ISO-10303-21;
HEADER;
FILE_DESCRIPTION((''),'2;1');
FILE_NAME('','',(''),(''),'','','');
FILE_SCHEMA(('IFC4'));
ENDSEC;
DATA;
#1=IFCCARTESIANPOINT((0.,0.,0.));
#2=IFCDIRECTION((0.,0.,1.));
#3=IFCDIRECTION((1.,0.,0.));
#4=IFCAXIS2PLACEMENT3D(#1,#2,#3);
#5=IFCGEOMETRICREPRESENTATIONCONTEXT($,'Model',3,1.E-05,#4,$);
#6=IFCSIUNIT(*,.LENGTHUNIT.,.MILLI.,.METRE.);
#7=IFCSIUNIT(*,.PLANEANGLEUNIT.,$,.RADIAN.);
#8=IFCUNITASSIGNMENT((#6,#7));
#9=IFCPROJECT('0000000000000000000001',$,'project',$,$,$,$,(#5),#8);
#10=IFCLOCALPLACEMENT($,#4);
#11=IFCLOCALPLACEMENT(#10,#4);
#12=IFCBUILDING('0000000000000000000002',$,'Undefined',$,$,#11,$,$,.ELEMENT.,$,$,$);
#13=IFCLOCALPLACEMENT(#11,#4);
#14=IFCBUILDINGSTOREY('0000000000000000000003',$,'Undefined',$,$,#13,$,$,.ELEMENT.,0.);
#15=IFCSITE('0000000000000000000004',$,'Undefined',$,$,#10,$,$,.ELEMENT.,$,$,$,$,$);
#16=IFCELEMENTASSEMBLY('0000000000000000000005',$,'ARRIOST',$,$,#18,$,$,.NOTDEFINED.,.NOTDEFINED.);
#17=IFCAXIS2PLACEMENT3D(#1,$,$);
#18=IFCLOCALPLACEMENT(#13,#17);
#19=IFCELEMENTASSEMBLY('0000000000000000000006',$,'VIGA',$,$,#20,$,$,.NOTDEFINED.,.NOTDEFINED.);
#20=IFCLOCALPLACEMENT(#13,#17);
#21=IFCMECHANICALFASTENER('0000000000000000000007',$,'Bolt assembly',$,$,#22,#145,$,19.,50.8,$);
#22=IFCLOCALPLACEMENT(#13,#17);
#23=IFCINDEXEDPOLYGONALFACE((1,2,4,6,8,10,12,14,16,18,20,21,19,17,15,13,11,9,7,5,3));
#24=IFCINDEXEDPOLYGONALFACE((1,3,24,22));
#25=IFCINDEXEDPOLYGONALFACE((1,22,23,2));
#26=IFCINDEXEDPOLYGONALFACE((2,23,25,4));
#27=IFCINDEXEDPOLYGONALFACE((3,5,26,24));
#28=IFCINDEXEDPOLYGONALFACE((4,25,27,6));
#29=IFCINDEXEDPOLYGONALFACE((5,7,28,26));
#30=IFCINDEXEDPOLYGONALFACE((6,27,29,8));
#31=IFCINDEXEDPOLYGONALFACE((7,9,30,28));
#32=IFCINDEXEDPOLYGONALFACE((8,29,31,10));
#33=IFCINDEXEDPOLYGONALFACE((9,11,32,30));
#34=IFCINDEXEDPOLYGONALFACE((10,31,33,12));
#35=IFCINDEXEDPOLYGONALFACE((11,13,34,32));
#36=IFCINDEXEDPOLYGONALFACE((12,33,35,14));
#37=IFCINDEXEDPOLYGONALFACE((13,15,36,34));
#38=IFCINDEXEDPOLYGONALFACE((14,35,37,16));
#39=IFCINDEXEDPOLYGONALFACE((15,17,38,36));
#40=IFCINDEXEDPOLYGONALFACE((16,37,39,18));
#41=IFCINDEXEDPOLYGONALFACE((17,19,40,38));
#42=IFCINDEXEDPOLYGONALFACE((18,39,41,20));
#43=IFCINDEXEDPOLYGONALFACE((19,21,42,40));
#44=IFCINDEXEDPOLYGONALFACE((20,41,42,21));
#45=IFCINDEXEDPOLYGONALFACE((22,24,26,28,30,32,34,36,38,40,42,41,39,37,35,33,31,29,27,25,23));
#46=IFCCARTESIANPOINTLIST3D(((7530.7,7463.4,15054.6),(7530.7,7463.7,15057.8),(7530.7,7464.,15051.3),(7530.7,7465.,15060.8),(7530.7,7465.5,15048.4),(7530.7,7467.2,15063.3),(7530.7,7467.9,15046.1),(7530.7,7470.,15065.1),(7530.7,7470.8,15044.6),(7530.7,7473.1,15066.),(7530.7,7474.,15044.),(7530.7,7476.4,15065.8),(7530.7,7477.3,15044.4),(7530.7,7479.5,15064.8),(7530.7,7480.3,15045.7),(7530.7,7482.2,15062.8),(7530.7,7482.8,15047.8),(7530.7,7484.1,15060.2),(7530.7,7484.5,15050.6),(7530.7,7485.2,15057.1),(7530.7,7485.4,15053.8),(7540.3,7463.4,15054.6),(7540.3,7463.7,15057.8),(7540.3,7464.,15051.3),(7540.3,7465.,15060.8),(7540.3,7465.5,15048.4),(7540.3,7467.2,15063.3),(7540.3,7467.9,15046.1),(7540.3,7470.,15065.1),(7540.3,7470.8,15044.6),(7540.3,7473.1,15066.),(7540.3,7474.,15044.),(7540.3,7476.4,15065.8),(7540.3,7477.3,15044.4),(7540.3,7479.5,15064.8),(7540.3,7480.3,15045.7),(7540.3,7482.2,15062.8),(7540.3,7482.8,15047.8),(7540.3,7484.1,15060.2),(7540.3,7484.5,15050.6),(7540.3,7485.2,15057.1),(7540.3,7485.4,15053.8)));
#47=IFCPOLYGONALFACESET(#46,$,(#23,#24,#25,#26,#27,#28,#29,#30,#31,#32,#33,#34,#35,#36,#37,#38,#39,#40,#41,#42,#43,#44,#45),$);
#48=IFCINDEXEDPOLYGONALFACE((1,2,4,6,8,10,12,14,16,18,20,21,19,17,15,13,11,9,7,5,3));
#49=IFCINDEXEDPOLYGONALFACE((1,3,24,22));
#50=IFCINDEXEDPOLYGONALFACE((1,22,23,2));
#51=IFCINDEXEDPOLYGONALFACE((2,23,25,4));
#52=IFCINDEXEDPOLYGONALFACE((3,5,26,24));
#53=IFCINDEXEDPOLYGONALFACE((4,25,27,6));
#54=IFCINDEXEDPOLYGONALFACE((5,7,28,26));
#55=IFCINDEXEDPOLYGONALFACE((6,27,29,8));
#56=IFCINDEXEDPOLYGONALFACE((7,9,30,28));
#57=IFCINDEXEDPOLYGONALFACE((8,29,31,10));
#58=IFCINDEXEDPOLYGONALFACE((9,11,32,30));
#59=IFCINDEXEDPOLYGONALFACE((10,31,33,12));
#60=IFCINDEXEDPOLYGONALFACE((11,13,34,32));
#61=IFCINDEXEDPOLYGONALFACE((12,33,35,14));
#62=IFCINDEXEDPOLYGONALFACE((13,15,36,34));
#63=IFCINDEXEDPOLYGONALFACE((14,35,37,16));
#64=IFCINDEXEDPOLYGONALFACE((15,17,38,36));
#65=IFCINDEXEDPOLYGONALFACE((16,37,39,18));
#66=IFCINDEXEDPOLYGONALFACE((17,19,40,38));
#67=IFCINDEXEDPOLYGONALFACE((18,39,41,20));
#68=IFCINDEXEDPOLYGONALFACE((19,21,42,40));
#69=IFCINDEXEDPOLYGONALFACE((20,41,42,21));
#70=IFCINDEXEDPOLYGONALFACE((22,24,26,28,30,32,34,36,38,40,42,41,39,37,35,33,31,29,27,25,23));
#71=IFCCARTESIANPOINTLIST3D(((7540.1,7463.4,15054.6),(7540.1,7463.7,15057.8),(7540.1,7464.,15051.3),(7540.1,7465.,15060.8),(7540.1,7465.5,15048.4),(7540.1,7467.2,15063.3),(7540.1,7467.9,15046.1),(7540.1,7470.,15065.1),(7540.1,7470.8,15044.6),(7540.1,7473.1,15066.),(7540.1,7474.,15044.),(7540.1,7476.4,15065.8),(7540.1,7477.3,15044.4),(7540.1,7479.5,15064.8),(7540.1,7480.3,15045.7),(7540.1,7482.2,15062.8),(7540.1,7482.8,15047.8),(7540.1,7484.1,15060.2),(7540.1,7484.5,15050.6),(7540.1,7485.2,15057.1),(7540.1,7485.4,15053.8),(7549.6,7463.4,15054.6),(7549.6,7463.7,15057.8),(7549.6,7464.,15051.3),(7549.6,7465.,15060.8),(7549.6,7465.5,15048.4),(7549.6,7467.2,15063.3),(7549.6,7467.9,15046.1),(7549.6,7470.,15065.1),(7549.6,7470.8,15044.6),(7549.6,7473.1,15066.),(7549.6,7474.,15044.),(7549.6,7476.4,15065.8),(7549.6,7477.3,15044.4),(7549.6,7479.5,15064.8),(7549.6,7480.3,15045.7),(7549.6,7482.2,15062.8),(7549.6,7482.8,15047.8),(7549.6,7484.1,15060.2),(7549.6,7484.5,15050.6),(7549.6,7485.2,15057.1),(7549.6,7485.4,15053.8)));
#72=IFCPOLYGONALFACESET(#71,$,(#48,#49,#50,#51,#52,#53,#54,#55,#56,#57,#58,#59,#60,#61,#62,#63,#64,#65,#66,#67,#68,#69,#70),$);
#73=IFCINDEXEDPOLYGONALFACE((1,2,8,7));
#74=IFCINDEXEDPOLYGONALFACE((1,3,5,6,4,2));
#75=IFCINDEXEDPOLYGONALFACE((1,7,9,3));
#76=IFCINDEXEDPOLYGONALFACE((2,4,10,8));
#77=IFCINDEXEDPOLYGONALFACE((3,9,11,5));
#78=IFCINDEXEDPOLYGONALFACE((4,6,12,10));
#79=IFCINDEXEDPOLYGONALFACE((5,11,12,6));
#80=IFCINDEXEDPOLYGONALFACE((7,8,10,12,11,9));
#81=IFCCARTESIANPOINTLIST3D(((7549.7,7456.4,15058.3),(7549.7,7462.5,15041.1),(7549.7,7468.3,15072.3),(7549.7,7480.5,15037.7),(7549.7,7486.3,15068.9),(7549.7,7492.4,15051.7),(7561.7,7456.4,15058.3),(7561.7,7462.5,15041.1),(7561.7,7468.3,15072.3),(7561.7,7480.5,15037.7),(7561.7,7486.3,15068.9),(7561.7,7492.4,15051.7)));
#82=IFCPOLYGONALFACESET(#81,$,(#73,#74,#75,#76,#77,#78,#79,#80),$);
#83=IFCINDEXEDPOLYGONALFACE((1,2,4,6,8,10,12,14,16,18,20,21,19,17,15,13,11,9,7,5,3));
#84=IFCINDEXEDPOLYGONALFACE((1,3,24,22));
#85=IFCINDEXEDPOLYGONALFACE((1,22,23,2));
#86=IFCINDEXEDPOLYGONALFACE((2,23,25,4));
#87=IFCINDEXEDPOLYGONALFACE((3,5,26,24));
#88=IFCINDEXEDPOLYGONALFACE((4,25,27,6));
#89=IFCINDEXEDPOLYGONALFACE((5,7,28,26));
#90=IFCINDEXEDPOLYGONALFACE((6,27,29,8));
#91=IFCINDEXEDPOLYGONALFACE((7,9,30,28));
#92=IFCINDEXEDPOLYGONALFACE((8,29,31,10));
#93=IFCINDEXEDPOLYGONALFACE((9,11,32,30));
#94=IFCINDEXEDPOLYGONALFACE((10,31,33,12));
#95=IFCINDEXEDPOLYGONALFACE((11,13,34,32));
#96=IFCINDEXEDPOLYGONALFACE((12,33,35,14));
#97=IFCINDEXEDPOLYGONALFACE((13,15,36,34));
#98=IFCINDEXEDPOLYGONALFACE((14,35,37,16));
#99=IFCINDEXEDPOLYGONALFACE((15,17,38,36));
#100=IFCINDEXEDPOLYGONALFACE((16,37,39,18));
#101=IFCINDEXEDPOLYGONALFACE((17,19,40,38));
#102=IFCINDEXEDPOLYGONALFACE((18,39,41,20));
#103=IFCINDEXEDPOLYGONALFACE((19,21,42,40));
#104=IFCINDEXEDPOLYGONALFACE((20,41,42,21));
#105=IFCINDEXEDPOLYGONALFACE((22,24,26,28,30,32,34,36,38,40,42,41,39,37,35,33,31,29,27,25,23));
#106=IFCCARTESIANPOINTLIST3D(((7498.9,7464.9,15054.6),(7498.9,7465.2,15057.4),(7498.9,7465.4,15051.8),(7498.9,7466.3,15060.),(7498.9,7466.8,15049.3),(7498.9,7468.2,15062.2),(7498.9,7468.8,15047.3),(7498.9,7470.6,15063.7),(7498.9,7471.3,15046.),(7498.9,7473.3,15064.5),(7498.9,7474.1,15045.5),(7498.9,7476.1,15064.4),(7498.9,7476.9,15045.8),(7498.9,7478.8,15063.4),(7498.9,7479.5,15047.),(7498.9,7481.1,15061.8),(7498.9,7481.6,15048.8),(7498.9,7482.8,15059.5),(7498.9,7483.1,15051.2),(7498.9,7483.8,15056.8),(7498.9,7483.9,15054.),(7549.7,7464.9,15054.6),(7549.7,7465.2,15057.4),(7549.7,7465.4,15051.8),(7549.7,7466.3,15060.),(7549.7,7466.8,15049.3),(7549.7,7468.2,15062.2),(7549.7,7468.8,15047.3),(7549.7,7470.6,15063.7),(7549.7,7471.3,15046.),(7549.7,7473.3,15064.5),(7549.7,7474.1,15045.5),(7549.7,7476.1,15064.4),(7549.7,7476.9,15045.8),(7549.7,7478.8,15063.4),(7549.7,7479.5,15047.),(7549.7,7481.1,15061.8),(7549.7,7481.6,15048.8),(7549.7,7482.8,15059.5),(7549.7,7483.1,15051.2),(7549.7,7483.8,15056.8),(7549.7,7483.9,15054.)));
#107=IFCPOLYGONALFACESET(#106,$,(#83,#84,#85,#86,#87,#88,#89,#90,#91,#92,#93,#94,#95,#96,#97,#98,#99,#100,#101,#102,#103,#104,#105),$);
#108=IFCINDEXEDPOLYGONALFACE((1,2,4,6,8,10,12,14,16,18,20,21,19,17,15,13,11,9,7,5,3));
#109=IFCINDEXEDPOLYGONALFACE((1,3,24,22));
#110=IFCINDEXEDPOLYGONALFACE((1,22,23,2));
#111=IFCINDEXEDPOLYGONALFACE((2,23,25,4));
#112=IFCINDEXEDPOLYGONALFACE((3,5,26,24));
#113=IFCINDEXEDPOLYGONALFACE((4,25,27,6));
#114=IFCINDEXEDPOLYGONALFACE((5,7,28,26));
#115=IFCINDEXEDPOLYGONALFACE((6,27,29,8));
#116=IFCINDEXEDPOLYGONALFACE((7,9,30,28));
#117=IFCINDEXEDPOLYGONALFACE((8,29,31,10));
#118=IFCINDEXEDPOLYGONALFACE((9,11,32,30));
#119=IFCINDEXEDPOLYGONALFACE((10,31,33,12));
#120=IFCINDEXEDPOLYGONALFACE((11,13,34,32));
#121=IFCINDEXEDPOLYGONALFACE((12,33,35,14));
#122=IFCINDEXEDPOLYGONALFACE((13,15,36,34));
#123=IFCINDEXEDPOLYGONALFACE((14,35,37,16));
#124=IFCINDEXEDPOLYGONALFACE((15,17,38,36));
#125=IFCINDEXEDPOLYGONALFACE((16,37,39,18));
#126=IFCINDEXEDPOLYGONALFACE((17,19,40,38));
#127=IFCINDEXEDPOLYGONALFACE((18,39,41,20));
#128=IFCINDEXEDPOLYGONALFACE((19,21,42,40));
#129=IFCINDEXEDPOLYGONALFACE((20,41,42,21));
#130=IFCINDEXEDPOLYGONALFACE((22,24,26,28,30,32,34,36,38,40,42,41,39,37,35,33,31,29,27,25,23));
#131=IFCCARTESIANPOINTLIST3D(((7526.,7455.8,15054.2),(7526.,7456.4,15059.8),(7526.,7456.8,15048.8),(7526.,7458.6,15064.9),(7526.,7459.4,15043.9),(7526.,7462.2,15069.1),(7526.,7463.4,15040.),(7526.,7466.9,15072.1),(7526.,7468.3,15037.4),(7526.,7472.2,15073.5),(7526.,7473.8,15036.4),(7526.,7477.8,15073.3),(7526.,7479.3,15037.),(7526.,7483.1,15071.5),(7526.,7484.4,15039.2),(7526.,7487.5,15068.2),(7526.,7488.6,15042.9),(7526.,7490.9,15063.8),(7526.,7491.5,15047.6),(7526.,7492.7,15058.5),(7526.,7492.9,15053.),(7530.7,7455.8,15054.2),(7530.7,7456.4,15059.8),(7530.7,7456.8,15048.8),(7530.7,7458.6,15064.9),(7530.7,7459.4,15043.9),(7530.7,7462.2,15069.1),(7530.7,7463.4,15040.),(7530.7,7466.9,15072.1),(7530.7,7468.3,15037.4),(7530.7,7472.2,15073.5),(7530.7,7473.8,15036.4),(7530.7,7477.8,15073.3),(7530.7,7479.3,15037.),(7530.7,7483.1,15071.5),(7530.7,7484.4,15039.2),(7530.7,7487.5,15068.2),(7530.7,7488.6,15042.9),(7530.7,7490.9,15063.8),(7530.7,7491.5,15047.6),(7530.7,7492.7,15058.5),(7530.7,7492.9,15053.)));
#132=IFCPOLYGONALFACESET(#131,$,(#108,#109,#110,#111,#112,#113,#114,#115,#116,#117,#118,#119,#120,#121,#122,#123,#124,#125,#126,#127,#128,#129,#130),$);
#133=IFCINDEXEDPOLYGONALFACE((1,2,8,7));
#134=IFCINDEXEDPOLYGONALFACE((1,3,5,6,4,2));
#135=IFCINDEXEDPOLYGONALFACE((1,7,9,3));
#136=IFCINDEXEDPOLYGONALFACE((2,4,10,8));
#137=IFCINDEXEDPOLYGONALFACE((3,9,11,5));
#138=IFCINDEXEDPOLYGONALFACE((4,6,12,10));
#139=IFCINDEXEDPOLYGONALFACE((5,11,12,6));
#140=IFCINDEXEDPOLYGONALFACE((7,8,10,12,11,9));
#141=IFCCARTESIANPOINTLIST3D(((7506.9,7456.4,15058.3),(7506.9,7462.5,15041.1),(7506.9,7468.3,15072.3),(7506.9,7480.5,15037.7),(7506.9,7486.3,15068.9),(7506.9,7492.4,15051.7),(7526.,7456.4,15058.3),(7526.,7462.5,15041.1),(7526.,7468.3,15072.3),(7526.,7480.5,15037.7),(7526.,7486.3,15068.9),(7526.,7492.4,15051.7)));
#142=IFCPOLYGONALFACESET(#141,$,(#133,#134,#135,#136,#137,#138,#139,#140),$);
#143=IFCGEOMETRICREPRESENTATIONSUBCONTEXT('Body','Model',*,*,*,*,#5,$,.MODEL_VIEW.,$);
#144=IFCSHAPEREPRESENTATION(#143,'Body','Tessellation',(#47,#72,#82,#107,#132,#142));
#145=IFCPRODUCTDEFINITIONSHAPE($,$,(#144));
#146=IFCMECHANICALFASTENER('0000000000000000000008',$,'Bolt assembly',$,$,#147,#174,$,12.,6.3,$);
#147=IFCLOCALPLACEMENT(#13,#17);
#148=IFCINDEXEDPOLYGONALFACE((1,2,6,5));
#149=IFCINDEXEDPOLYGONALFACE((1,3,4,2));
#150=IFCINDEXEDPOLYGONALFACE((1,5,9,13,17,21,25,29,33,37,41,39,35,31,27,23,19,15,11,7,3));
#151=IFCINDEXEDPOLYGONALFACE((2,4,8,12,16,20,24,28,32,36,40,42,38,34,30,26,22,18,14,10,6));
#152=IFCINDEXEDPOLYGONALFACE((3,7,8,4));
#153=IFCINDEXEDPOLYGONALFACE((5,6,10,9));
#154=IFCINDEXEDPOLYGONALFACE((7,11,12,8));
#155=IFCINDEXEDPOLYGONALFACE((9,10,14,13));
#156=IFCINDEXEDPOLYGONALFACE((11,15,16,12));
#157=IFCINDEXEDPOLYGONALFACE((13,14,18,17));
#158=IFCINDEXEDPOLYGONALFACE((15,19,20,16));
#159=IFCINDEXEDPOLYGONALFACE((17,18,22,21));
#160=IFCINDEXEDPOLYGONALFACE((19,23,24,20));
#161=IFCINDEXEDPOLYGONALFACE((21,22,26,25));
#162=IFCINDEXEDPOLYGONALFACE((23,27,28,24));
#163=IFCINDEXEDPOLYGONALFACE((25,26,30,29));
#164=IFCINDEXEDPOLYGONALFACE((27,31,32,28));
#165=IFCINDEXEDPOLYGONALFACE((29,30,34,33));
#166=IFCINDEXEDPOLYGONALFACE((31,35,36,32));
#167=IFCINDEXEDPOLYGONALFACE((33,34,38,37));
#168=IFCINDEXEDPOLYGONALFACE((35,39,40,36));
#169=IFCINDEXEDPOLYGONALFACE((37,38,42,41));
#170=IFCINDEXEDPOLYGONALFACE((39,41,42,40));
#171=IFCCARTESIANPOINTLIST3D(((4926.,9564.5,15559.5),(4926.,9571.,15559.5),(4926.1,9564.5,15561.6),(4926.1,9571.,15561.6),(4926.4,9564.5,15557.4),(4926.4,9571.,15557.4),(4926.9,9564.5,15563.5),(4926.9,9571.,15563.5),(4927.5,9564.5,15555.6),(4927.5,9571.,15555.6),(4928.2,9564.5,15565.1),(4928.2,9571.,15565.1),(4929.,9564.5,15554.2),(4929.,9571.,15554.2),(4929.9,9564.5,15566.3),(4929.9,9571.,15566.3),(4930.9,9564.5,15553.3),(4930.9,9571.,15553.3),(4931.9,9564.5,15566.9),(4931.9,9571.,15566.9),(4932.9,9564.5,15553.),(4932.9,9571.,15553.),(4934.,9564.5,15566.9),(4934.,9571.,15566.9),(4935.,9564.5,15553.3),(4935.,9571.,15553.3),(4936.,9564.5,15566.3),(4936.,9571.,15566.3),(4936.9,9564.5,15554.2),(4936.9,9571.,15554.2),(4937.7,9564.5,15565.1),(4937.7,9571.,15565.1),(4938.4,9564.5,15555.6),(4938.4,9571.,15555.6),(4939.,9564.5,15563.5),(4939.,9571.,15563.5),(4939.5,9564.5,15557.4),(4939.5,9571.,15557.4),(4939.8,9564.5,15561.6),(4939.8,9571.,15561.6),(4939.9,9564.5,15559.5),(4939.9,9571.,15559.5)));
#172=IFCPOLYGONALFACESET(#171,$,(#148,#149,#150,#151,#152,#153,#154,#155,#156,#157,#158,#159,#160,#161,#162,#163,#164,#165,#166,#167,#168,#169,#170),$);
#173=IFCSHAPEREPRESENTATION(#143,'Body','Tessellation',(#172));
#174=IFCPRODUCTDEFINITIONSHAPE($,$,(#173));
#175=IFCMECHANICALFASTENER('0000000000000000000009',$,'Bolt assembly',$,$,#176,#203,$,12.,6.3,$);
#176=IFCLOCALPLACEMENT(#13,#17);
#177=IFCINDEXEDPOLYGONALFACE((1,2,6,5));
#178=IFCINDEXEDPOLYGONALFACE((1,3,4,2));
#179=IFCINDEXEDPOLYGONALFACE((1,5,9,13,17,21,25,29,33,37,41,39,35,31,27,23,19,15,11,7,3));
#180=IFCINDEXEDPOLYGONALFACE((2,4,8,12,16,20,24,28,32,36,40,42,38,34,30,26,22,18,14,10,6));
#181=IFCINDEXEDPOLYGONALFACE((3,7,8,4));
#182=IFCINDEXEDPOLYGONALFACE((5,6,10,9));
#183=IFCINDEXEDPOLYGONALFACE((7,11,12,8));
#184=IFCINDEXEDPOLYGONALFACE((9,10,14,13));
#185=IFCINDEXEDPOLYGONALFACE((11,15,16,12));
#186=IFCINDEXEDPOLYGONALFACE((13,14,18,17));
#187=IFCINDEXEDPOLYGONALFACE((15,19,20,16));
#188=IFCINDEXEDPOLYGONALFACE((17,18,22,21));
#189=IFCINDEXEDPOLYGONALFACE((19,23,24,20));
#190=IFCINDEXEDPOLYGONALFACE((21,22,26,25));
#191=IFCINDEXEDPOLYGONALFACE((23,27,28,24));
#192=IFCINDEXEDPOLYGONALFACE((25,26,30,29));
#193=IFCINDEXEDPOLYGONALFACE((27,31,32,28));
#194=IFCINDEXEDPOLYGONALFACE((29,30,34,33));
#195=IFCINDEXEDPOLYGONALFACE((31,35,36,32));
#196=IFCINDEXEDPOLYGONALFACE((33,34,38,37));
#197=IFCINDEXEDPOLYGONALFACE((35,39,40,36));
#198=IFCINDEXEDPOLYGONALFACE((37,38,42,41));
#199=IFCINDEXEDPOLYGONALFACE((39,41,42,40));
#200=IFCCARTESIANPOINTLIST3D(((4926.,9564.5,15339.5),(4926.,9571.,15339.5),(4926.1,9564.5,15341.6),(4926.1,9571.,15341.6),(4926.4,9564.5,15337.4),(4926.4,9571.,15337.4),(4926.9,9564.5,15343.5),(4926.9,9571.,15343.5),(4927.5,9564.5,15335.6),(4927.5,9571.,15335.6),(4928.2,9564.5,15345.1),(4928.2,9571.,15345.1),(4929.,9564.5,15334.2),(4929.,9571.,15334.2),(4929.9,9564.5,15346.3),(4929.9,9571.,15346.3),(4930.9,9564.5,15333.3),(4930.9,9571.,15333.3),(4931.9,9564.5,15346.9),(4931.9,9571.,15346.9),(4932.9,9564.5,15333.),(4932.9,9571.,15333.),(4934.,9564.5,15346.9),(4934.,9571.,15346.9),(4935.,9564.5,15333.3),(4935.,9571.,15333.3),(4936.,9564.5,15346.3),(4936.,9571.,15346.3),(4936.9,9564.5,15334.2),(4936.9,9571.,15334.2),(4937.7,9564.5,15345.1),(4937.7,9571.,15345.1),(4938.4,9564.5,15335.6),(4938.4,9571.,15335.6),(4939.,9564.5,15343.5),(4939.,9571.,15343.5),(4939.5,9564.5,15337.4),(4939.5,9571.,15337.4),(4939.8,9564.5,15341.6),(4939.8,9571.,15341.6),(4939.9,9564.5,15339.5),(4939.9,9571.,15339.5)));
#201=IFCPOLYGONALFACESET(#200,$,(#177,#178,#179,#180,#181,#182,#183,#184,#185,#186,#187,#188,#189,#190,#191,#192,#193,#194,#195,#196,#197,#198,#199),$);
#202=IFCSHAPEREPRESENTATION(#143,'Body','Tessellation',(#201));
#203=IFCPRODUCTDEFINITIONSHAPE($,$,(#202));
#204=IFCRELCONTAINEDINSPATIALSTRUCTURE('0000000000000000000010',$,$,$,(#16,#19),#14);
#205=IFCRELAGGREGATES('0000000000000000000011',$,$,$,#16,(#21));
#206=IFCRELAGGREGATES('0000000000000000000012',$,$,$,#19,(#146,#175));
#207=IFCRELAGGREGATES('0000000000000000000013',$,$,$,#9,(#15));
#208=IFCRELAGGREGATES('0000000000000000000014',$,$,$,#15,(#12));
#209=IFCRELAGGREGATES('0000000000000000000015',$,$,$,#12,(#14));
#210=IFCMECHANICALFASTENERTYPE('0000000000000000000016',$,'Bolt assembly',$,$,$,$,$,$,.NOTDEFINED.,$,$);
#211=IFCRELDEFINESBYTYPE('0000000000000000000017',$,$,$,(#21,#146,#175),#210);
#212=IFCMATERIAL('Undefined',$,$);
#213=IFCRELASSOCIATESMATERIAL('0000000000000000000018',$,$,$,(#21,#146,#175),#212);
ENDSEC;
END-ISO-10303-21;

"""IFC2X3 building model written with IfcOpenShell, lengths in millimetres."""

from ifc_helpers import new_model, si_unit, frame, origin_with_axes, origin_2d_with_axis, place, context, subcontext, project, spatial, polyline, circle, outline, extrude, source, transform, mapped, material, type_object, element, aggregate, save


model = new_model("IFC2X3")

# Units and contexts
model_context = context("Model", 3, precision=1e-05, world=origin_with_axes())
body_context = subcontext(model_context, "Body", "Model", "MODEL_VIEW")
ifc_project = project(units=[si_unit("LENGTHUNIT", "METRE", prefix="MILLI"), si_unit("PLANEANGLEUNIT", "RADIAN")], contexts=[model_context])

# Site, building, storey
site_placement = place(None, origin_with_axes())
site = spatial("IfcSite", under=ifc_project, at=site_placement, Name="Undefined", CompositionType="ELEMENT")
building_placement = place(site_placement, origin_with_axes())
building = spatial("IfcBuilding", under=site, at=building_placement, Name="Undefined", CompositionType="ELEMENT")
storey_placement = place(building_placement, origin_with_axes())
storey = spatial("IfcBuildingStorey", under=building, at=storey_placement, Name="Undefined", CompositionType="ELEMENT", Elevation=0.0)

# Element assembly
assembly_1_placement = place(storey_placement, origin_with_axes())
assembly_1 = element("IfcElementAssembly", 1, at=assembly_1_placement, inside=storey, Name="ARRIOST", AssemblyPlace="NOTDEFINED", PredefinedType="NOTDEFINED")

# Element assembly
assembly_2_placement = place(storey_placement, origin_with_axes())
assembly_2 = element("IfcElementAssembly", 2, at=assembly_2_placement, inside=storey, Name="VIGA", AssemblyPlace="NOTDEFINED", PredefinedType="NOTDEFINED")

# Mechanical fastener
ifc_material_1 = material(Name="Undefined")
mechanical_fastener_type = type_object("IfcMechanicalFastenerType", Name="Bolt assembly")
shared_shape_1 = source(origin_with_axes(), body_context, "Body", "SweptSolid", [
    extrude(circle(Radius=11.0, at=origin_2d_with_axis()), frame((0.0, 4.6, 0.0), z_axis=(0.0, 1.0, 0.0), x_axis=(1.0, 0.0, 0.0)), (0.0, 0.0, 1.0), 9.6),
    extrude(circle(Radius=11.0, at=origin_2d_with_axis()), frame((0.0, -4.6, 0.0), z_axis=(0.0, 1.0, 0.0), x_axis=(1.0, 0.0, 0.0)), (0.0, 0.0, 1.0), 9.5),
    extrude(outline(polyline([(15.9, -9.2), (15.9, 9.2), (0.0, 18.3), (-15.9, 9.2), (-15.9, -9.2), (0.0, -18.3), (15.9, -9.2)])), frame((0.0, -16.7, 0.0), z_axis=(0.0, 1.0, 0.0), x_axis=(1.0, 0.0, 0.0)), (0.0, 0.0, 1.0), 11.9),
    extrude(circle(Radius=9.5, at=origin_2d_with_axis()), frame((0.0, -4.7, 0.0), z_axis=(0.0, 1.0, 0.0), x_axis=(1.0, 0.0, 0.0)), (0.0, 0.0, 1.0), 50.8),
    extrude(circle(Radius=18.7, at=origin_2d_with_axis()), frame((0.0, 14.2, 0.0), z_axis=(0.0, 1.0, 0.0), x_axis=(1.0, 0.0, 0.0)), (0.0, 0.0, 1.0), 4.8),
    extrude(outline(polyline([(15.9, -9.2), (15.9, 9.2), (0.0, 18.3), (-15.9, 9.2), (-15.9, -9.2), (0.0, -18.3), (15.9, -9.2)])), frame((0.0, 19.0, 0.0), z_axis=(0.0, 1.0, 0.0), x_axis=(1.0, 0.0, 0.0)), (0.0, 0.0, 1.0), 19.1),
])
mechanical_fastener_1_placement = place(assembly_1_placement, frame((7545.0, 7474.4, 15055.0), z_axis=(0.0, 0.333429, -0.942775), x_axis=(0.0, -0.942775, -0.333429)))
mechanical_fastener_1 = element("IfcMechanicalFastener", 3, at=mechanical_fastener_1_placement, type_object=mechanical_fastener_type, material=ifc_material_1, Name="Bolt assembly", NominalDiameter=19.0, NominalLength=50.8, context=body_context, shape_type="MappedRepresentation", body=[
    mapped(shared_shape_1, transform((0.0, 0.0, 0.0))),
])
aggregate(assembly_1, [mechanical_fastener_1])

# Mechanical fasteners
shared_shape_2 = source(origin_with_axes(), body_context, "Body", "SweptSolid", [
    extrude(circle(Radius=7.0, at=origin_2d_with_axis()), frame((0.0, -16.3, 0.0), z_axis=(0.0, 1.0, 0.0), x_axis=(1.0, 0.0, 0.0)), (0.0, 0.0, 1.0), 6.5),
])
mechanical_fastener_2_placement = place(assembly_2_placement, frame((4932.9, 9580.9, 15560.0), z_axis=(1.0, 0.0, 0.0), x_axis=(0.0, 0.0, -1.0)))
mechanical_fastener_2 = element("IfcMechanicalFastener", 4, at=mechanical_fastener_2_placement, type_object=mechanical_fastener_type, material=ifc_material_1, Name="Bolt assembly", NominalDiameter=12.0, NominalLength=6.3, context=body_context, shape_type="MappedRepresentation", body=[
    mapped(shared_shape_2, transform((0.0, 0.0, 0.0))),
])
mechanical_fastener_3_placement = place(assembly_2_placement, frame((4932.9, 9580.9, 15340.0), z_axis=(1.0, 0.0, 0.0), x_axis=(0.0, 0.0, -1.0)))
mechanical_fastener_3 = element("IfcMechanicalFastener", 5, at=mechanical_fastener_3_placement, type_object=mechanical_fastener_type, material=ifc_material_1, Name="Bolt assembly", NominalDiameter=12.0, NominalLength=6.3, context=body_context, shape_type="MappedRepresentation", body=[
    mapped(shared_shape_2, transform((0.0, 0.0, 0.0))),
])
aggregate(assembly_2, [mechanical_fastener_2, mechanical_fastener_3])

save(model, "model.ifc")
